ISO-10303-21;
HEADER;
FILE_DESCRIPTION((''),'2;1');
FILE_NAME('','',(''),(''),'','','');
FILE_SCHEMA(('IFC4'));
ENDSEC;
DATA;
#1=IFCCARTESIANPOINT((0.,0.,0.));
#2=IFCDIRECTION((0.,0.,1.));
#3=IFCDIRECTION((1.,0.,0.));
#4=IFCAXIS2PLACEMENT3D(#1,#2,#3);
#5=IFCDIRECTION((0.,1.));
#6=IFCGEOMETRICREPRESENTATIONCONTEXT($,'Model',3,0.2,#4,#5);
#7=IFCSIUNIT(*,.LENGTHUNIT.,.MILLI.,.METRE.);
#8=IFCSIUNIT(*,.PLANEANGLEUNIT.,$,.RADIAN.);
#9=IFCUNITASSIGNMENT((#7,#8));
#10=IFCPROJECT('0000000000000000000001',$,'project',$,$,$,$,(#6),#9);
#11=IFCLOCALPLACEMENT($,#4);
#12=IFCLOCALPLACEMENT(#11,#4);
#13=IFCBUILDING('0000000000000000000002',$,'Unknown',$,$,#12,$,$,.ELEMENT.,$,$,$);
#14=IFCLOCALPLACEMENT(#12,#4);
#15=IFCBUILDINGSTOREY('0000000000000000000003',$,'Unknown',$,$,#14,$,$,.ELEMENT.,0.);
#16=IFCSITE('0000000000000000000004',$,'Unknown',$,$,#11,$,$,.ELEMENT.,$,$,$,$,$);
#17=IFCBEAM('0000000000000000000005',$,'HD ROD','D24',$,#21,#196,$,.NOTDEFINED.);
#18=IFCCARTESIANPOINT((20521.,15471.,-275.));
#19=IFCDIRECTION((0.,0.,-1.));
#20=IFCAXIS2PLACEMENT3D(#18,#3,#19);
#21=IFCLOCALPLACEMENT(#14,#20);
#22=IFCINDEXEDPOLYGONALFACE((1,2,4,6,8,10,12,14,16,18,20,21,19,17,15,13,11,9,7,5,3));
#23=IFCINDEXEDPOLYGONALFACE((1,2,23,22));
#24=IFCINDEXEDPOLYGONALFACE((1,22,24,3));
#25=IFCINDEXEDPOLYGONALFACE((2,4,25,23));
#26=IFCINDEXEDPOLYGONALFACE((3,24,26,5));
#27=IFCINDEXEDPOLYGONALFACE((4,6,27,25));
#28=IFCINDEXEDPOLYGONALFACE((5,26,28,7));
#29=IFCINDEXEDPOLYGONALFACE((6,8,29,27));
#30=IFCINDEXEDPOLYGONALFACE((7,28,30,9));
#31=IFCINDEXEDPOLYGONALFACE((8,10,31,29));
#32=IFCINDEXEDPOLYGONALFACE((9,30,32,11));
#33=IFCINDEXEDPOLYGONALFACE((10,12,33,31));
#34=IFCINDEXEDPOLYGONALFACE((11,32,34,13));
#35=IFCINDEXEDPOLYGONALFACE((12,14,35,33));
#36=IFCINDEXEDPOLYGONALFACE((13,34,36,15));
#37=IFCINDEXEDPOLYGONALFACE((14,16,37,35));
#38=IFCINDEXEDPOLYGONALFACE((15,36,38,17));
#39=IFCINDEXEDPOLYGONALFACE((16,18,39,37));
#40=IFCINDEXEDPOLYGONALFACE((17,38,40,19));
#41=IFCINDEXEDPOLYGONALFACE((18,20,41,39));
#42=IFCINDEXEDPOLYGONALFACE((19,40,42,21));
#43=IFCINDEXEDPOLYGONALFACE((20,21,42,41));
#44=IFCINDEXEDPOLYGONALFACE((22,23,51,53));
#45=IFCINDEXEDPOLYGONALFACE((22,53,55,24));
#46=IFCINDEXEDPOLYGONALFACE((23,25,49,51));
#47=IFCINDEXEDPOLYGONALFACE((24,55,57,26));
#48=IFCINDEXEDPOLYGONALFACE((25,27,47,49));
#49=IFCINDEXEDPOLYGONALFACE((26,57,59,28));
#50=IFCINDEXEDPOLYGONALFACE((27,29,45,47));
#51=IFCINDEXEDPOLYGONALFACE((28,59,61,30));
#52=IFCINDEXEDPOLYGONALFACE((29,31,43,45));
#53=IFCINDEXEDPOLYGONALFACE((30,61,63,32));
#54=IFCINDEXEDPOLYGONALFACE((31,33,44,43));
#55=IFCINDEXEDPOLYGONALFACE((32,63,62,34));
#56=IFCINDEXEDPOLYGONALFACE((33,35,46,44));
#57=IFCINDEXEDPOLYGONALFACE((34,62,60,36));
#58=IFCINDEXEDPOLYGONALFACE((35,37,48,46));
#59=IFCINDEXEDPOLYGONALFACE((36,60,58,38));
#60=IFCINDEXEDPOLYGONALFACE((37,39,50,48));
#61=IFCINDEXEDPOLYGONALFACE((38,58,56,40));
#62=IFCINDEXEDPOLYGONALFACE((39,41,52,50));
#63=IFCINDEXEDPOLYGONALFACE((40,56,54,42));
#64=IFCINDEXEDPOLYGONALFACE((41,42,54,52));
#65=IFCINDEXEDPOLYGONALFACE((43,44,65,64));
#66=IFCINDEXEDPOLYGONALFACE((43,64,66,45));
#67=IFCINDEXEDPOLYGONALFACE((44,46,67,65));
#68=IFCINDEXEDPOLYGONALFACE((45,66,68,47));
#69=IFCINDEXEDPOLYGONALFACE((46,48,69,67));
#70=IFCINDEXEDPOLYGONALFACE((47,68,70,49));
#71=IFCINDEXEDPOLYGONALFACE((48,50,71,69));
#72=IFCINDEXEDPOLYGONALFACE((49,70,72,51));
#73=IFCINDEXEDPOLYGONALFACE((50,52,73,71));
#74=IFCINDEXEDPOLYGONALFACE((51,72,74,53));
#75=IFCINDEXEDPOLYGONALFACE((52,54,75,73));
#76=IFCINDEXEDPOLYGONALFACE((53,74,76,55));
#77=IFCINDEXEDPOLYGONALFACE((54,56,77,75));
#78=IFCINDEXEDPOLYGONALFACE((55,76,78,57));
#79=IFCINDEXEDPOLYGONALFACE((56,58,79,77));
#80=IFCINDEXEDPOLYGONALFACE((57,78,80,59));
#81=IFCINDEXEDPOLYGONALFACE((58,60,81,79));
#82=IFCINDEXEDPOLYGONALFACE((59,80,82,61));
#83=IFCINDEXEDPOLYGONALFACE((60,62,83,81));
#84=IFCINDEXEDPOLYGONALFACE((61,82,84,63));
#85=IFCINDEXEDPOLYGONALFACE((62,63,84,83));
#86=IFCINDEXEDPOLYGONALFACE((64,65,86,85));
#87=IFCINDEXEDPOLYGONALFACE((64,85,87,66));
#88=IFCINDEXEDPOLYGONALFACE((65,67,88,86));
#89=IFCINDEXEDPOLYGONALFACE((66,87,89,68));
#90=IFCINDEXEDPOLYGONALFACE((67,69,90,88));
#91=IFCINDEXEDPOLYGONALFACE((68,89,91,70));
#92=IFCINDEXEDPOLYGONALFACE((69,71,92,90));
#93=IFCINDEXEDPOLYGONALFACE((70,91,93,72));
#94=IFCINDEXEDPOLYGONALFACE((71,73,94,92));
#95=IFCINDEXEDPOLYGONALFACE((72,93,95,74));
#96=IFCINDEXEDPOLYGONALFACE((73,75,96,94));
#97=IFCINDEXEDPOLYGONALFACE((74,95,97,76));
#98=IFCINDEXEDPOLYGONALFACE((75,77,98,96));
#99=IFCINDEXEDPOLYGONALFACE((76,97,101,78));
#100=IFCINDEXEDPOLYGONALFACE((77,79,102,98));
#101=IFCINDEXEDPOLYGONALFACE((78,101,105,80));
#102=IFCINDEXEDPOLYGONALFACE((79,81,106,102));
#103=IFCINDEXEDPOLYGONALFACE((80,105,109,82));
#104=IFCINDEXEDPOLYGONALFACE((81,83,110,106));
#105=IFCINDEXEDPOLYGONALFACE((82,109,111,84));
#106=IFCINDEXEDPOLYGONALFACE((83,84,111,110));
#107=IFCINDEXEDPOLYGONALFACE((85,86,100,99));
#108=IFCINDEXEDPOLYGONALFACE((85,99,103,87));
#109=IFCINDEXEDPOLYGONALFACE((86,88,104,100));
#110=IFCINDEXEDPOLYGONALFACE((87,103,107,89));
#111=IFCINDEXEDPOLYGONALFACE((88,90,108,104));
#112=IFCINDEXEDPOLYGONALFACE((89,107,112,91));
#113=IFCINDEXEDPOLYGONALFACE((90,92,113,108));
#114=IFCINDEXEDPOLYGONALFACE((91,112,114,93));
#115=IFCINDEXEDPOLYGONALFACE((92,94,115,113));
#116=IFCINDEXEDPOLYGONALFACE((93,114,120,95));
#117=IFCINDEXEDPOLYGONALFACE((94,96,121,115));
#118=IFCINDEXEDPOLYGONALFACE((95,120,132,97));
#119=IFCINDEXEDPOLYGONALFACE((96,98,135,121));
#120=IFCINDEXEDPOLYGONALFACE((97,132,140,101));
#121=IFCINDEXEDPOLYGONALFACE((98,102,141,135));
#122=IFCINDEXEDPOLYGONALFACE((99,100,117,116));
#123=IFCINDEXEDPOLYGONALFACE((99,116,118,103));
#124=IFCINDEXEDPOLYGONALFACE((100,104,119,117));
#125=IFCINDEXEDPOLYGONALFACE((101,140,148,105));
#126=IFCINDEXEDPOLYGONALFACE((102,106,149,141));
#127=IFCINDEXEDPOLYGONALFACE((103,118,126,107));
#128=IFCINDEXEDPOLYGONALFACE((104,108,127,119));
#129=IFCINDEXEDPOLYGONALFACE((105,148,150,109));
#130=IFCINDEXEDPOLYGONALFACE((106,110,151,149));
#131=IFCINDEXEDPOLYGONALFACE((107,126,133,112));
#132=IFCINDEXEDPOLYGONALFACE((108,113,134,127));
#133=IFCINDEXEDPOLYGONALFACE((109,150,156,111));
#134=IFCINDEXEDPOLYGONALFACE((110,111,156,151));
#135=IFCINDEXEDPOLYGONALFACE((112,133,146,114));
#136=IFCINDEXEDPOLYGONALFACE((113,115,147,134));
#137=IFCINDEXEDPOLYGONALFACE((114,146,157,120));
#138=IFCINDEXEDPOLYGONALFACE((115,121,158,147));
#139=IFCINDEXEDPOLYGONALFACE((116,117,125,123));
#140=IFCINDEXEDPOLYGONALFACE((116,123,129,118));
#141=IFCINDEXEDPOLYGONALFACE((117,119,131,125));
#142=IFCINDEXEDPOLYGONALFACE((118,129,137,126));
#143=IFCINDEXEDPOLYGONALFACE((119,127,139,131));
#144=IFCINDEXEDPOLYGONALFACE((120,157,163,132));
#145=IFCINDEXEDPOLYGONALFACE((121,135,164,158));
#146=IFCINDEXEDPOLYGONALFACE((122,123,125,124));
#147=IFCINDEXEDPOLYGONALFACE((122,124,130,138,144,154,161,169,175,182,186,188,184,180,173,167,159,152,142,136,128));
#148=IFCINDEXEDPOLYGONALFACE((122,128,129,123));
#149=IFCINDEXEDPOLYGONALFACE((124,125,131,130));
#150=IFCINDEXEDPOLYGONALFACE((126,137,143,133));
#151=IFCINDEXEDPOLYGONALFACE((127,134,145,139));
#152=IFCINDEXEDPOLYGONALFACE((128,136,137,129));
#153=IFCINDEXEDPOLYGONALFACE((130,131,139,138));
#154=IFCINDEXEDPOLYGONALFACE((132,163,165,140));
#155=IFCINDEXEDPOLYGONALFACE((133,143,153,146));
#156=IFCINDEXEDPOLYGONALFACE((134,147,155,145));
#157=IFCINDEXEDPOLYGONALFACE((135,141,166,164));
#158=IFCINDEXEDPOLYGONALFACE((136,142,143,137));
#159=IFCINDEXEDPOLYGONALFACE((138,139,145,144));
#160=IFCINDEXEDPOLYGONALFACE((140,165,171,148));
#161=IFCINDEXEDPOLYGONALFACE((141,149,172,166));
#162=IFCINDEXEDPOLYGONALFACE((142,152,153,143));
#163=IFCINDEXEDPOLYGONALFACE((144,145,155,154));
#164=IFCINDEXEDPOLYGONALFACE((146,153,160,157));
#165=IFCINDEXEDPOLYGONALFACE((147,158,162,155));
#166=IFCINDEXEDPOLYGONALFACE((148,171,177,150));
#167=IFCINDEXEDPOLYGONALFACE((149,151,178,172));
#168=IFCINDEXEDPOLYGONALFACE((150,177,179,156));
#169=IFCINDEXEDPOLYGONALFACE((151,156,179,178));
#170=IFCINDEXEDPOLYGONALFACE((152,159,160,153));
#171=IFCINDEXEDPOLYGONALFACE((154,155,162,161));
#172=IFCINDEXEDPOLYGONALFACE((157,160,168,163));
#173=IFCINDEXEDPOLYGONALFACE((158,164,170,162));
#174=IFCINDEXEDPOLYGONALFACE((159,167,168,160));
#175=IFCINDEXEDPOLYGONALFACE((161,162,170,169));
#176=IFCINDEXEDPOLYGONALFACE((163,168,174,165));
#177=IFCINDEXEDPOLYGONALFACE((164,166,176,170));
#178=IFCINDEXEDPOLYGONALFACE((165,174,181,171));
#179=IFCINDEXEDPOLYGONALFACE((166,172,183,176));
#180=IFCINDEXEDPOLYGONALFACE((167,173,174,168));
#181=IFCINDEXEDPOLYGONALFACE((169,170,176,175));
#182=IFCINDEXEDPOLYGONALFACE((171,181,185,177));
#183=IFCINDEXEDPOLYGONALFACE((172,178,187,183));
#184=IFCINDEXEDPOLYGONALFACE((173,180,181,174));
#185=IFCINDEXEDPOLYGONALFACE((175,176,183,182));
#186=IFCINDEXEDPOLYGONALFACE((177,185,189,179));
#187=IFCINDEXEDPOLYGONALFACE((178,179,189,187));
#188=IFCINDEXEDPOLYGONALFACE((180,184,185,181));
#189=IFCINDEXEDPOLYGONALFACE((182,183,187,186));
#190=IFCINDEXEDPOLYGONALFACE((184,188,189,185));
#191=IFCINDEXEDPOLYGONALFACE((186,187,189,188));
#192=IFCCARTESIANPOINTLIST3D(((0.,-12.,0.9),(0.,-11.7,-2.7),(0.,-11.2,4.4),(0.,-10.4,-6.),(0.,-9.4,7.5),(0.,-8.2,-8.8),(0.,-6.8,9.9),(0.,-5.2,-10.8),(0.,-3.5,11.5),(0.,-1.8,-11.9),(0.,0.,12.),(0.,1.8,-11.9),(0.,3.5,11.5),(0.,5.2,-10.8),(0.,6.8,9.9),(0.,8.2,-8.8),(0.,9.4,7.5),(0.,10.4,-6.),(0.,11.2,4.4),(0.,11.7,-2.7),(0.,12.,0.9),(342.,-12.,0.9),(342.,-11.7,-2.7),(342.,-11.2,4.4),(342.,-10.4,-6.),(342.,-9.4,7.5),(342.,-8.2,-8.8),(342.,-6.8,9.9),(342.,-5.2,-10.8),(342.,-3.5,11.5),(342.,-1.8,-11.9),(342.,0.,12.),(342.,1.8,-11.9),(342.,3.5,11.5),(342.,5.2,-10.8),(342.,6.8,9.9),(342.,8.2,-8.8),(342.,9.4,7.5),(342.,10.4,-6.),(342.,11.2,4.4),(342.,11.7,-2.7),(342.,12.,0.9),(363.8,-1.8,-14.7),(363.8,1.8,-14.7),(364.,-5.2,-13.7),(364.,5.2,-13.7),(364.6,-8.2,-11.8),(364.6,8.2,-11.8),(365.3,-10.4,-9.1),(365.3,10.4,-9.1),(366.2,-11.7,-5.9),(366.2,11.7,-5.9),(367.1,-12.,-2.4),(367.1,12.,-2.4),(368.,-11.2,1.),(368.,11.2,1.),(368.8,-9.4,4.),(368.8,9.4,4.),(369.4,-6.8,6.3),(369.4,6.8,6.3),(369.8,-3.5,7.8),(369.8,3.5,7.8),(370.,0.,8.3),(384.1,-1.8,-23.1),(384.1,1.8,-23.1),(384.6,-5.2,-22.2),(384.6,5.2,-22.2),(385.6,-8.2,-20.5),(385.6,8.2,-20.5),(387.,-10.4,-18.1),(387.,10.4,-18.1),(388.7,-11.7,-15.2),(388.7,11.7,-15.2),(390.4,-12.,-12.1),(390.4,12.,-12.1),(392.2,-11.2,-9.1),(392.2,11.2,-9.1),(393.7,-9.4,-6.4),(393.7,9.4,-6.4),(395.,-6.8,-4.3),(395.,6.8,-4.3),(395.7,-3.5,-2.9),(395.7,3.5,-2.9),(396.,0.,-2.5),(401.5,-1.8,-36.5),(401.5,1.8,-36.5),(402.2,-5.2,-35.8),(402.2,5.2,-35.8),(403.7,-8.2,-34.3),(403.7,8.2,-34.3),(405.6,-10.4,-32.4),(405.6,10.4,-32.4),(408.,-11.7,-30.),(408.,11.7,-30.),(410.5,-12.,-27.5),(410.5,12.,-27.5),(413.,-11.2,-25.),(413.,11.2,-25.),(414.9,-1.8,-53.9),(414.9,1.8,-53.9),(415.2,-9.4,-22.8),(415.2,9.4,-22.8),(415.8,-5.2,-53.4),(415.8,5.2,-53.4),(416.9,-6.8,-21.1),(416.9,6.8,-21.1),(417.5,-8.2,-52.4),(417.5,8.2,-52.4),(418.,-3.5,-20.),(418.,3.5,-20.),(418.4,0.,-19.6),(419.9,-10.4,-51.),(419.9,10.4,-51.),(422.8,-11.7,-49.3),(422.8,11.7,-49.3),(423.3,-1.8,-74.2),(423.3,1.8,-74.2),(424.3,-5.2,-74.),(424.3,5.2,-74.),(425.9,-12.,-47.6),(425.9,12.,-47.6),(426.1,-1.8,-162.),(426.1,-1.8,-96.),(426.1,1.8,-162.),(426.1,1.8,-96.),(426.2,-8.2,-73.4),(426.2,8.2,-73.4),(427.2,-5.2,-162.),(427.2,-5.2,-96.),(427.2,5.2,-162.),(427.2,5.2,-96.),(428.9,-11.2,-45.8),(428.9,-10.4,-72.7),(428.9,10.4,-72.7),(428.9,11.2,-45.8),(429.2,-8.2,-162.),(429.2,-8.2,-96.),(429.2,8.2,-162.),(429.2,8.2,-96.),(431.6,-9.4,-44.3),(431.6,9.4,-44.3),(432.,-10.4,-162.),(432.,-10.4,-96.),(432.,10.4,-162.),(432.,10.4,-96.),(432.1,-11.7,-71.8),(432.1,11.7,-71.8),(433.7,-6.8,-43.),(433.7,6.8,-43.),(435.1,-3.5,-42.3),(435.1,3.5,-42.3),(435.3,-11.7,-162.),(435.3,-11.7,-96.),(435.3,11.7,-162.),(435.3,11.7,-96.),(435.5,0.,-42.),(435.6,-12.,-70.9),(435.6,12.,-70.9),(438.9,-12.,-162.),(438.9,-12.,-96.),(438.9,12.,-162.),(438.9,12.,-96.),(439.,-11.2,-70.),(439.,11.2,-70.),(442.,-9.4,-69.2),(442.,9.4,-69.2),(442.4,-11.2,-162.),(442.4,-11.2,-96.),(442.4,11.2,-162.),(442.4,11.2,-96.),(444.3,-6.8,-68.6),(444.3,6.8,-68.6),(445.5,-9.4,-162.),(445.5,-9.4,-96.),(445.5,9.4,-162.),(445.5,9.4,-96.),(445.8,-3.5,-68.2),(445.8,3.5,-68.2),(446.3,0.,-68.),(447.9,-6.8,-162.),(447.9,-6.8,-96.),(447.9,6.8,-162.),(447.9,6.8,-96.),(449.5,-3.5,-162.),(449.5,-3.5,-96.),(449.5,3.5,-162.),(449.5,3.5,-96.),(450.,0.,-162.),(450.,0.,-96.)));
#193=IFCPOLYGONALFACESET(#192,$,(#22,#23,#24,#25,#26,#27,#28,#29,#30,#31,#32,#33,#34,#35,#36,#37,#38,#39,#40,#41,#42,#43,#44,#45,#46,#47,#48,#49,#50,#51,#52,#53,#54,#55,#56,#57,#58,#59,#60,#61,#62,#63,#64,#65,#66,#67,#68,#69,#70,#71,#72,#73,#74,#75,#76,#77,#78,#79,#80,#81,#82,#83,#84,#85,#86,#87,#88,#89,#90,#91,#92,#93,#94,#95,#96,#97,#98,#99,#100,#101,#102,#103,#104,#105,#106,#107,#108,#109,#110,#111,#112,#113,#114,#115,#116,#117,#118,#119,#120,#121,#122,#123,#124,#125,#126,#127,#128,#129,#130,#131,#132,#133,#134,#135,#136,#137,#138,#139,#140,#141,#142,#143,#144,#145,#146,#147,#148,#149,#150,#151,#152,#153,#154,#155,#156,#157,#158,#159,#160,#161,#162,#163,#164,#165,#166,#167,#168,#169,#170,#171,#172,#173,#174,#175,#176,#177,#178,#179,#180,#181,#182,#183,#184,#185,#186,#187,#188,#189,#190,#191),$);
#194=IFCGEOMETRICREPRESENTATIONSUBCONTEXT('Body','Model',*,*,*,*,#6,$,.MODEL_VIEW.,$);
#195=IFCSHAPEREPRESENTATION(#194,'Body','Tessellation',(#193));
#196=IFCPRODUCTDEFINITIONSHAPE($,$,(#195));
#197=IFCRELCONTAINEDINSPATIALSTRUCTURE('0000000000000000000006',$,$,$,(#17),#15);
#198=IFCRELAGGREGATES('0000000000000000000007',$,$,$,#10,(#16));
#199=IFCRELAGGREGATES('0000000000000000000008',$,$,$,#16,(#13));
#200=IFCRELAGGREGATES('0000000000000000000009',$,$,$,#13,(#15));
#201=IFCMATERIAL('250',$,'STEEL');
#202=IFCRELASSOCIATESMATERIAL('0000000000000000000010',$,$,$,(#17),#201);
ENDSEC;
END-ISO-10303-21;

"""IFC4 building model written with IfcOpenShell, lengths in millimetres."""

from ifc_helpers import new_model, entity, si_unit, direction, frame, origin_with_axes, place, context, subcontext, project, spatial, material, element, save


model = new_model("IFC4")

# Units and contexts
model_context = context("Model", 3, precision=0.2, world=origin_with_axes(), true_north=direction((0.0, 1.0)))
body_context = subcontext(model_context, "Body", "Model", "MODEL_VIEW")
ifc_project = project(units=[si_unit("LENGTHUNIT", "METRE", prefix="MILLI"), si_unit("PLANEANGLEUNIT", "RADIAN")], contexts=[model_context])

# Site, building, storey
site_placement = place(None, origin_with_axes())
site = spatial("IfcSite", under=ifc_project, at=site_placement, Name="Unknown", CompositionType="ELEMENT")
building_placement = place(site_placement, origin_with_axes())
building = spatial("IfcBuilding", under=site, at=building_placement, Name="Unknown", CompositionType="ELEMENT")
storey_placement = place(building_placement, origin_with_axes())
storey = spatial("IfcBuildingStorey", under=building, at=storey_placement, Name="Unknown", CompositionType="ELEMENT", Elevation=0.0)

# Shared definitions
ifc_material_1 = material(Name="250", Category="STEEL")

# Beam
beam_1_placement = place(storey_placement, frame((20521.0, 15471.0, -275.0), z_axis=(1.0, 0.0, 0.0), x_axis=(0.0, 0.0, -1.0)))
element("IfcBeam", 1, at=beam_1_placement, inside=storey, material=ifc_material_1, Name="HD ROD", Description="D24", PredefinedType="NOTDEFINED", context=body_context, shape_type="SolidModel", body=[
    entity("IfcSweptDiskSolid", entity("IfcIndexedPolyCurve", entity("IfcCartesianPointList3D", [[0.0, 0.0, 0.0], [342.0, 0.0, 0.0], [409.9, 0.0, -28.1], [438.0, 0.0, -96.0], [438.0, 0.0, -162.0]]), [entity("IfcLineIndex", [1, 2]), entity("IfcArcIndex", [2, 3, 4]), entity("IfcLineIndex", [4, 5])]), 12.0),
])

save(model, "model.ifc")
